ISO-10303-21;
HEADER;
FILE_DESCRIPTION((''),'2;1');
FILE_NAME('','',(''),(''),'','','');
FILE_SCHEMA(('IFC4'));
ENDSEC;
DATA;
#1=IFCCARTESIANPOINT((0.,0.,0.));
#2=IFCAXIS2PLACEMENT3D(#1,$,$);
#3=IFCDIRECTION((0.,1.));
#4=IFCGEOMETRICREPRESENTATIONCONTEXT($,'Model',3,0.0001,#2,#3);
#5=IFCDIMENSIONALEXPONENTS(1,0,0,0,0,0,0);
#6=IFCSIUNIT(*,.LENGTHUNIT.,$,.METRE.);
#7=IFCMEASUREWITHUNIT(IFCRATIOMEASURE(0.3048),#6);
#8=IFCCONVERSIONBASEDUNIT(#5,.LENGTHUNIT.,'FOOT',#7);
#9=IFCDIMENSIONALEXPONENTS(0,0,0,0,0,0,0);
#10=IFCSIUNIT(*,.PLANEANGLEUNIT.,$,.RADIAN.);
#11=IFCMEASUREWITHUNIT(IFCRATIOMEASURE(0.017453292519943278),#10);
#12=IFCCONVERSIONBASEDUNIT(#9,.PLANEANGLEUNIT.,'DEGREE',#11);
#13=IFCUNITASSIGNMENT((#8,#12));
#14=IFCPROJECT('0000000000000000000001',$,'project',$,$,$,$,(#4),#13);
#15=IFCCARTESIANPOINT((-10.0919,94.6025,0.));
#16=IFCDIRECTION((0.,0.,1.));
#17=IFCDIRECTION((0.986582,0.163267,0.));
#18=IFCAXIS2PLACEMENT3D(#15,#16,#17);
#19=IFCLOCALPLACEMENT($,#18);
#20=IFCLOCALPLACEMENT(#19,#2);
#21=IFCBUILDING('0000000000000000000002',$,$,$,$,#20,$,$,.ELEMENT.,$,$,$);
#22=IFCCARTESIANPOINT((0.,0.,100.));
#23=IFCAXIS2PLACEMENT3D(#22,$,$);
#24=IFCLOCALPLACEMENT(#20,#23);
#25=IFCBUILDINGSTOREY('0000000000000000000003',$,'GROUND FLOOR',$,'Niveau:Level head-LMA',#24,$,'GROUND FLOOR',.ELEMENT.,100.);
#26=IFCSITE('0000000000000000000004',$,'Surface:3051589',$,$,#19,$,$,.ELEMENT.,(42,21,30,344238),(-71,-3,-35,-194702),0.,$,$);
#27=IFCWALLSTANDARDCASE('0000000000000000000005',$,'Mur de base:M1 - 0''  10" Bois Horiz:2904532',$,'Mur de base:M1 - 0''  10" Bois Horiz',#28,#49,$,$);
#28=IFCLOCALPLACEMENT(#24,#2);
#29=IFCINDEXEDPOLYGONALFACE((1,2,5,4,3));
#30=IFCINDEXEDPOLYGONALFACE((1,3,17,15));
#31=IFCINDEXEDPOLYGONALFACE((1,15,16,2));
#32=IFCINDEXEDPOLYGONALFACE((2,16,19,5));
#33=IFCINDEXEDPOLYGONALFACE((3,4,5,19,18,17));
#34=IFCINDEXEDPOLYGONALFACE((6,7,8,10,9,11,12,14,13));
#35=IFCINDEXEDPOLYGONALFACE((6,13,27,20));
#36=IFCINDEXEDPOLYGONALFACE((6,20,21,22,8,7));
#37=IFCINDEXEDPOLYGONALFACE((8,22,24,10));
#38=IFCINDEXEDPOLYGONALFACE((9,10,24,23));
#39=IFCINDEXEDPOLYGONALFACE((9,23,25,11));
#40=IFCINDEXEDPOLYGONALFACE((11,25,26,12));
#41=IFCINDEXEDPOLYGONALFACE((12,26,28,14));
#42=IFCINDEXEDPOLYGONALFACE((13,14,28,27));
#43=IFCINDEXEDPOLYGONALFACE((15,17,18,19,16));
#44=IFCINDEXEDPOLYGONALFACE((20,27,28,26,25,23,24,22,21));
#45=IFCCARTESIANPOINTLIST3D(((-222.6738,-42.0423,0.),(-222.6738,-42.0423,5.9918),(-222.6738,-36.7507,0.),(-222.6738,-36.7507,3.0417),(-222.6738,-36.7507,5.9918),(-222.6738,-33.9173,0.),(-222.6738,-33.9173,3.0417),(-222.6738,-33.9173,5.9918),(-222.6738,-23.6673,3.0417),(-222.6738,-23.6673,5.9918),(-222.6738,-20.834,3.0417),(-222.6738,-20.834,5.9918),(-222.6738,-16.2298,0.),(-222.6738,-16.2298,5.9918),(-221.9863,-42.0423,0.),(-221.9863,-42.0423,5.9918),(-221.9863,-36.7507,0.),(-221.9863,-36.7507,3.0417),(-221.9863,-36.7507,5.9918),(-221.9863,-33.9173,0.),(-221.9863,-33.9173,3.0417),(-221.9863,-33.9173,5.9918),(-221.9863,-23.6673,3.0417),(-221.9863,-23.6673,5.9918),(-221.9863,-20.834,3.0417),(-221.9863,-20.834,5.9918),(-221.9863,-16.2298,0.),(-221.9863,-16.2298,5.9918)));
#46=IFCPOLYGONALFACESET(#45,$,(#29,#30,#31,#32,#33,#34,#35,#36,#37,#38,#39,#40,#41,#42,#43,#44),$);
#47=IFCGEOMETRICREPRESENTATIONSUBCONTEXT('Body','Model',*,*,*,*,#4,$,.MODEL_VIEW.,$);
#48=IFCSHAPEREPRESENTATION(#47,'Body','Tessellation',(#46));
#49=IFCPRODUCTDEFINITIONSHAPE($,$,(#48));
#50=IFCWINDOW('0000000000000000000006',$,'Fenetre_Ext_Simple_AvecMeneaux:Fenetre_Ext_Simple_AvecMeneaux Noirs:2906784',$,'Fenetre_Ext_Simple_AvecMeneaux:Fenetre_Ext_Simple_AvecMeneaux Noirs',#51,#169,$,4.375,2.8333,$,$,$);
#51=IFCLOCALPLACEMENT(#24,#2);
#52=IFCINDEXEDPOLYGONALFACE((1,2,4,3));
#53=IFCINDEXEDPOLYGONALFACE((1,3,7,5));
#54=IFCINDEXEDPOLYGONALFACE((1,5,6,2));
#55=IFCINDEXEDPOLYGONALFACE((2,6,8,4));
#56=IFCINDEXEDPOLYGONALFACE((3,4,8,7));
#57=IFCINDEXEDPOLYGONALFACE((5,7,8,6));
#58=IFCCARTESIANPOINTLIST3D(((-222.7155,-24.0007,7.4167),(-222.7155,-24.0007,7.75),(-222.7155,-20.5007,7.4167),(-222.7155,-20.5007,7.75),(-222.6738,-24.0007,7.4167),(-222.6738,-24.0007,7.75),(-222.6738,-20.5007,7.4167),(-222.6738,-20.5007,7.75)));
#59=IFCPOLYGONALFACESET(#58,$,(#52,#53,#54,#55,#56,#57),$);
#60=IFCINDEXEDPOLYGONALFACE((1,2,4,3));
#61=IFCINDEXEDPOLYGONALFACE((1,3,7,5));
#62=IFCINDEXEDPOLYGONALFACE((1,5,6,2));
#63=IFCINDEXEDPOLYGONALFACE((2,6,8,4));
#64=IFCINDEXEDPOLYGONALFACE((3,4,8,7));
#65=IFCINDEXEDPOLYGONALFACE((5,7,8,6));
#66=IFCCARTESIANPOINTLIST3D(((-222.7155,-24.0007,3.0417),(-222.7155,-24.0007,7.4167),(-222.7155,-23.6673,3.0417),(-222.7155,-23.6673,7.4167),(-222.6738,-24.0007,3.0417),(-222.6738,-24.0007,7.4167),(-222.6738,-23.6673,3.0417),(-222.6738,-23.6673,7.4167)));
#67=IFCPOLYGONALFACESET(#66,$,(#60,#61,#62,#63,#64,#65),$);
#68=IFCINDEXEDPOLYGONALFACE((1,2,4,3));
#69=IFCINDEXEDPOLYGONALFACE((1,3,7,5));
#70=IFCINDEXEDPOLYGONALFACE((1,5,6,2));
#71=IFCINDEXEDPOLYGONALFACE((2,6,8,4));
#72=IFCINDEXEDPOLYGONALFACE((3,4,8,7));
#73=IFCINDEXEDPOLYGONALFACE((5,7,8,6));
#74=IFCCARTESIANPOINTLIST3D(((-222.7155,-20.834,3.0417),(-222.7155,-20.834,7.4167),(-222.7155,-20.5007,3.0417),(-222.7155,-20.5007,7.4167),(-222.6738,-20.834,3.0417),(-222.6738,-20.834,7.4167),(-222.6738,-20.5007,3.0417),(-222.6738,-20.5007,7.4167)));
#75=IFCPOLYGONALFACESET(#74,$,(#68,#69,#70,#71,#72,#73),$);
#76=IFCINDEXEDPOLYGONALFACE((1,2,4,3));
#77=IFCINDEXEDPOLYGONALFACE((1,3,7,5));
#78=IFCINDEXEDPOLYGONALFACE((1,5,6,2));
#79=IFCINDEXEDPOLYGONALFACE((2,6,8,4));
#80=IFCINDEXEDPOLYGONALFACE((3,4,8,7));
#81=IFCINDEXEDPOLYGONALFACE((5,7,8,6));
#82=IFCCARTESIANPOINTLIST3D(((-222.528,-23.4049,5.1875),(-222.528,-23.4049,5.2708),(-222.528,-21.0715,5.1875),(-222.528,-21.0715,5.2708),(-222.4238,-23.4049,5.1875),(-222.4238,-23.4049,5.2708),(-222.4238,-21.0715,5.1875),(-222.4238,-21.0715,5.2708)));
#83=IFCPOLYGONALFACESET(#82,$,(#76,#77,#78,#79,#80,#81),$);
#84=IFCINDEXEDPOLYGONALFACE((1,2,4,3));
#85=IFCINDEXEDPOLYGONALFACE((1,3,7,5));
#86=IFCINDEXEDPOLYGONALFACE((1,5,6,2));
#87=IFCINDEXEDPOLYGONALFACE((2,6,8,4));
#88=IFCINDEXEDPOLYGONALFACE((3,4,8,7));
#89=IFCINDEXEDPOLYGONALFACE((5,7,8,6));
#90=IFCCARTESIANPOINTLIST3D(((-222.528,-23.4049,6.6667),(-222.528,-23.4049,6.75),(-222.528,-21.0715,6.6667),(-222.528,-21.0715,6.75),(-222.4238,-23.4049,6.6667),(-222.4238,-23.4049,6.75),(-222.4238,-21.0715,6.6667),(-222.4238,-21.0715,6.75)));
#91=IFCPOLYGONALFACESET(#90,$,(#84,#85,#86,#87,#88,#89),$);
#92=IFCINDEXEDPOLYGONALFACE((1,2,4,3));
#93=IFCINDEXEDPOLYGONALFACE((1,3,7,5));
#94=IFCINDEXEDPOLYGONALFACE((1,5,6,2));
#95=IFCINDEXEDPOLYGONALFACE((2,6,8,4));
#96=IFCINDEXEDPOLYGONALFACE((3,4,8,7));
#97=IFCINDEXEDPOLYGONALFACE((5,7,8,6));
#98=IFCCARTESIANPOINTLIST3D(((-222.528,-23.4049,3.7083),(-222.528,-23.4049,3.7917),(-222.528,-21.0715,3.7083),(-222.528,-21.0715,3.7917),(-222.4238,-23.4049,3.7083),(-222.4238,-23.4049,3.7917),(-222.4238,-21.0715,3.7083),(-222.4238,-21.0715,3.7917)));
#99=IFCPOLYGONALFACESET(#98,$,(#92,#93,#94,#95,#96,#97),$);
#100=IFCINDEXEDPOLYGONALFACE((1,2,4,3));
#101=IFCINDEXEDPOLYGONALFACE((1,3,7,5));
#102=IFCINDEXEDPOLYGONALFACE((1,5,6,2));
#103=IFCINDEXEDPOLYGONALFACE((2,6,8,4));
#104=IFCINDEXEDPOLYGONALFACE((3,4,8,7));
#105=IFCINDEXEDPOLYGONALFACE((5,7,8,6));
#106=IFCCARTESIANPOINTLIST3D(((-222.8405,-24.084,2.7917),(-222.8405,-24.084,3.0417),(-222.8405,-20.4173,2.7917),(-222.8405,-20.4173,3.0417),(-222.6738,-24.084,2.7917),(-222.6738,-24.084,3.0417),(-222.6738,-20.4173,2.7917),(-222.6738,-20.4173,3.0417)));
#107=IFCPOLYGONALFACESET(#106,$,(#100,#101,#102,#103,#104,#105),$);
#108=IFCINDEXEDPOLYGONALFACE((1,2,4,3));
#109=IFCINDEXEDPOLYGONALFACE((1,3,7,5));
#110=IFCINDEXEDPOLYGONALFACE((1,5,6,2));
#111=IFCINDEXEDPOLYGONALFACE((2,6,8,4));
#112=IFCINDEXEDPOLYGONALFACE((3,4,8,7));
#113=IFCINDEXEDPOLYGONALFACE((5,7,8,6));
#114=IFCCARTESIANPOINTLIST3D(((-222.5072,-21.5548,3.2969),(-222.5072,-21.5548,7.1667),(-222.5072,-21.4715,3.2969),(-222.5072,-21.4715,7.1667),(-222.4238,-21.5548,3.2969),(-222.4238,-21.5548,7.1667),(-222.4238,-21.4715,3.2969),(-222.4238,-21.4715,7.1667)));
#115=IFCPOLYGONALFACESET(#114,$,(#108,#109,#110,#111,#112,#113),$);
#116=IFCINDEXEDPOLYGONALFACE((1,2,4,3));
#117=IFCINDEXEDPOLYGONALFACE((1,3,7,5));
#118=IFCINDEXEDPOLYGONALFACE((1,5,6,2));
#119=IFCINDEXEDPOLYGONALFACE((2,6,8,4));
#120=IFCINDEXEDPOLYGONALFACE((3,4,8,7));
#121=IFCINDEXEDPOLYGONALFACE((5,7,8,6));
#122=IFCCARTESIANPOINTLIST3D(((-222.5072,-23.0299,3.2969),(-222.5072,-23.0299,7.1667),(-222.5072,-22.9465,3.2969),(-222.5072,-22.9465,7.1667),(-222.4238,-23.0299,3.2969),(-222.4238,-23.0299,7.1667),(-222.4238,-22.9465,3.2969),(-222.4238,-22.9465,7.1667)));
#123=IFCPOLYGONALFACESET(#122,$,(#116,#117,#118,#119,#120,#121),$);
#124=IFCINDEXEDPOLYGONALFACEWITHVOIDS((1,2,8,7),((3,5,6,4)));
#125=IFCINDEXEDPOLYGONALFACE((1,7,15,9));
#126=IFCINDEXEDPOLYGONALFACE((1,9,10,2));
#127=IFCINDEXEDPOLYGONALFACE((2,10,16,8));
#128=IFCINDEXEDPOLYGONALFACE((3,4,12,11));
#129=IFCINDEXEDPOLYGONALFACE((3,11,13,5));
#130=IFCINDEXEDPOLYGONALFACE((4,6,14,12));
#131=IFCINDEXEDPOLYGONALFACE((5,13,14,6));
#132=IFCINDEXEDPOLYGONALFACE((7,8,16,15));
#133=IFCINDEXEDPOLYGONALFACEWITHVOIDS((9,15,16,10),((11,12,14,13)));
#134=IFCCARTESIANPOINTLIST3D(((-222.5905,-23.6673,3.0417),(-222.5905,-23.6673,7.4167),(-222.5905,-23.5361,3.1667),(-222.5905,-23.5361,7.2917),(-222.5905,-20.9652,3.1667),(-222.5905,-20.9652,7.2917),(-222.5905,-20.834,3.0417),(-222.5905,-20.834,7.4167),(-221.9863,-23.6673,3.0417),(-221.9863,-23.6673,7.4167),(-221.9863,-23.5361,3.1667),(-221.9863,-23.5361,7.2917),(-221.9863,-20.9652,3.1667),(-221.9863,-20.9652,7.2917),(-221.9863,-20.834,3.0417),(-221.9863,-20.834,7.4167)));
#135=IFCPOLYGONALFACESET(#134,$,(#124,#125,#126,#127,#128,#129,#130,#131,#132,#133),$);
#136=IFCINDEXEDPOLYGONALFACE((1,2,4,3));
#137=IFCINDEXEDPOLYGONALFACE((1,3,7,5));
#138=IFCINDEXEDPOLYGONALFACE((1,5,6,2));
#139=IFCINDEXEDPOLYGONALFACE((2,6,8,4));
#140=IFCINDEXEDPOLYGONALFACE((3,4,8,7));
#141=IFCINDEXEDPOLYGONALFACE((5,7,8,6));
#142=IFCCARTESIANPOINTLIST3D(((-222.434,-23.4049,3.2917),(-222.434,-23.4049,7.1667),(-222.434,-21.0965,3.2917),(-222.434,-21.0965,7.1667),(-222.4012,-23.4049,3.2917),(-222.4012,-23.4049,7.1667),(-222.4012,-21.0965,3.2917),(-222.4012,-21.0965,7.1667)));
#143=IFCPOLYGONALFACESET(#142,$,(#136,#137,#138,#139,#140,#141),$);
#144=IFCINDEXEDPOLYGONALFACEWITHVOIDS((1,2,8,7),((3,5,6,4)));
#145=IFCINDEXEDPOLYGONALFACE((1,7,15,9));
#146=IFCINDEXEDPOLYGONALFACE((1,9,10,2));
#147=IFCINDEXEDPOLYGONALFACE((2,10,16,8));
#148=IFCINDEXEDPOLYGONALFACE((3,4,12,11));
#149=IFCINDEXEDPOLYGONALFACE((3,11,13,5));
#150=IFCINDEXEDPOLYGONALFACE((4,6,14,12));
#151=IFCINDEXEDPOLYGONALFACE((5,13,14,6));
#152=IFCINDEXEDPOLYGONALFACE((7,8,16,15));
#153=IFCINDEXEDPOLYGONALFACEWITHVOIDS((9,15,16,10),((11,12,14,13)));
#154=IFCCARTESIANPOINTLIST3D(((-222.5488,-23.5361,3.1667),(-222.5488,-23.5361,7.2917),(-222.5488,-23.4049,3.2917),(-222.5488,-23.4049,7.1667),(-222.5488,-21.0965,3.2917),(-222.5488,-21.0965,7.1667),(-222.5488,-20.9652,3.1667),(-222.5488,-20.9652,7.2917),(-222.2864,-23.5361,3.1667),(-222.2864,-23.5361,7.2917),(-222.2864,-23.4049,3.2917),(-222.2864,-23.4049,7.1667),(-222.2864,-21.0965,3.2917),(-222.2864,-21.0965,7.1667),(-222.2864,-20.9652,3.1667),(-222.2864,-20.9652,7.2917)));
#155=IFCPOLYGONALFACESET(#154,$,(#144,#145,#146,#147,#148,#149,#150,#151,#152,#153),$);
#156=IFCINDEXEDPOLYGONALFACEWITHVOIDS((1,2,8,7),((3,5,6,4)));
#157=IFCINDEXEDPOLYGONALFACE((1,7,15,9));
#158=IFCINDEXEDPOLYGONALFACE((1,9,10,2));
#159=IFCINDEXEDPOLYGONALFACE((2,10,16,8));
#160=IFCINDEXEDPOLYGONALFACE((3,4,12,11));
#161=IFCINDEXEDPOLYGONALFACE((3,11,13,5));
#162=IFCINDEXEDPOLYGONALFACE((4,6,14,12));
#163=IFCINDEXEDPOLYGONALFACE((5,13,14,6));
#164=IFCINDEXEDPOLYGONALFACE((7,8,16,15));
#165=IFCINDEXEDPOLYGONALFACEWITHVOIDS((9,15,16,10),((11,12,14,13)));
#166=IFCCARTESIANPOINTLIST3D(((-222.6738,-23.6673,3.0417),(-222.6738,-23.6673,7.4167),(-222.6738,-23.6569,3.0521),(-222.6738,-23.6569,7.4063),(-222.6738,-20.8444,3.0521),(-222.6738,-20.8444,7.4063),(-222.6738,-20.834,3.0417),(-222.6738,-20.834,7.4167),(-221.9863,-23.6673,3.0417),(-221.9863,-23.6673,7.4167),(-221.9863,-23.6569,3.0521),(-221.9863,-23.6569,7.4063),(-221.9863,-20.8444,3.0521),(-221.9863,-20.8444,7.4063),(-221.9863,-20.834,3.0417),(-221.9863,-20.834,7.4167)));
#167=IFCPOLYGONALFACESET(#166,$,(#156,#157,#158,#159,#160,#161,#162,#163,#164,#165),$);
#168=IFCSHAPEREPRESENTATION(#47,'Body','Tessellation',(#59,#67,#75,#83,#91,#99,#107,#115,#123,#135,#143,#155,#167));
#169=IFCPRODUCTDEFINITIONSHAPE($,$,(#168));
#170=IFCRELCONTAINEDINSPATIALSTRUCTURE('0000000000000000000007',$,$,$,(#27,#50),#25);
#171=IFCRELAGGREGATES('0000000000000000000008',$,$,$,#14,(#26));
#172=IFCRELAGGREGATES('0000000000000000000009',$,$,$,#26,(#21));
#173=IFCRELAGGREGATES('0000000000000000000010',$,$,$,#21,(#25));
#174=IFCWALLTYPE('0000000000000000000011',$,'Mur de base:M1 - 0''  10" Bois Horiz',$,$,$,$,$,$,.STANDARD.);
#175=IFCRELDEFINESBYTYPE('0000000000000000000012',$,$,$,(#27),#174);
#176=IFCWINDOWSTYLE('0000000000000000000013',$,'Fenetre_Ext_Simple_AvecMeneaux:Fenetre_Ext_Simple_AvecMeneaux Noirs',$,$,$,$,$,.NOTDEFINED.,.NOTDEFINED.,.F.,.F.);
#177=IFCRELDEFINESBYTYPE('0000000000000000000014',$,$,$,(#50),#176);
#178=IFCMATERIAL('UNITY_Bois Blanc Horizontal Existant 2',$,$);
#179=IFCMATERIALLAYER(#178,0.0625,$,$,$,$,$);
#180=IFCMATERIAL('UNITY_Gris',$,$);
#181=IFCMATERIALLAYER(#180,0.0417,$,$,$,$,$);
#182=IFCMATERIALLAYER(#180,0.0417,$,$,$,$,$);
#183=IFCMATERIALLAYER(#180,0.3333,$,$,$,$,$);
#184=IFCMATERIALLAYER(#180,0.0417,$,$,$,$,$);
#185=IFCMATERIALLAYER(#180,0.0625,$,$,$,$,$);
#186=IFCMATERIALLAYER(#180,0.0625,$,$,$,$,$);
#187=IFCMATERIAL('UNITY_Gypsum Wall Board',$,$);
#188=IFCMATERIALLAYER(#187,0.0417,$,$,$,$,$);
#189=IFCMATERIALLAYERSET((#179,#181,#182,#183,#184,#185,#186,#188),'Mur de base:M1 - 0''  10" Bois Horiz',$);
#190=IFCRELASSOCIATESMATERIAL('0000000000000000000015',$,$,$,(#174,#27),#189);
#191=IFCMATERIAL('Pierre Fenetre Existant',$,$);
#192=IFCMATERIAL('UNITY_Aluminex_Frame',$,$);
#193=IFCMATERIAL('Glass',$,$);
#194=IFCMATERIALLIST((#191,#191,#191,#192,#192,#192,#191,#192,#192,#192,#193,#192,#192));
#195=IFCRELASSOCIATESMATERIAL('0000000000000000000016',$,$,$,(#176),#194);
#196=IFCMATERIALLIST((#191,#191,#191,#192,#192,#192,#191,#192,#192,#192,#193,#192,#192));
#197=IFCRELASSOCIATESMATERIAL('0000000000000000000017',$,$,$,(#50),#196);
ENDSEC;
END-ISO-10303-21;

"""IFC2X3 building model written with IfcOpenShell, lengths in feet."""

from ifc_helpers import new_model, entity, si_unit, converted_unit, direction, frame, frame_2d, origin, origin_2d_with_axis, place, context, subcontext, project, spatial, polyline, rectangle, outline, extrude, clip, bounded_halfspace, source, transform, mapped, material, material_list, layer, layer_set, layer_usage, type_object, type_shapes, element, fill, save


model = new_model("IFC2X3")

# Units and contexts
model_context = context("Model", 3, precision=0.0001, world=origin(), true_north=direction((0.0, 1.0)))
body_context = subcontext(model_context, "Body", "Model", "MODEL_VIEW")
ifc_project = project(units=[converted_unit("LENGTHUNIT", "FOOT", entity("IfcRatioMeasure", 0.3048), si_unit("LENGTHUNIT", "METRE"), dimensions=[1, 0, 0, 0, 0, 0, 0]), converted_unit("PLANEANGLEUNIT", "DEGREE", entity("IfcRatioMeasure", 0.017453292519943278), si_unit("PLANEANGLEUNIT", "RADIAN"), dimensions=[0, 0, 0, 0, 0, 0, 0])], contexts=[model_context])

# Site, building, storey
site_placement = place(None, frame((-10.0919, 94.6025, 0.0), z_axis=(0.0, 0.0, 1.0), x_axis=(0.986582, 0.163267, 0.0)))
site = spatial("IfcSite", under=ifc_project, at=site_placement, Name="Surface:3051589", CompositionType="ELEMENT", RefLatitude=(42, 21, 30, 344238), RefLongitude=(-71, -3, -35, -194702), RefElevation=0.0)
building_placement = place(site_placement, origin())
building = spatial("IfcBuilding", under=site, at=building_placement, CompositionType="ELEMENT")
storey_placement = place(building_placement, frame((0.0, 0.0, 100.0)))
storey = spatial("IfcBuildingStorey", under=building, at=storey_placement, Name="GROUND FLOOR", ObjectType="Niveau:Level head-LMA", LongName="GROUND FLOOR", CompositionType="ELEMENT", Elevation=100.0)

# Shared definitions
ifc_material_1 = material(Name="UNITY_Bois Blanc Horizontal Existant 2")
ifc_layer_1 = layer(ifc_material_1, 0.0625)
ifc_material_2 = material(Name="UNITY_Gris")
ifc_layer_2 = layer(ifc_material_2, 0.0417)
ifc_layer_3 = layer(ifc_material_2, 0.0417)
ifc_layer_4 = layer(ifc_material_2, 0.3333)
ifc_layer_5 = layer(ifc_material_2, 0.0417)
ifc_layer_6 = layer(ifc_material_2, 0.0625)
ifc_layer_7 = layer(ifc_material_2, 0.0625)
ifc_material_3 = material(Name="UNITY_Gypsum Wall Board")
ifc_layer_8 = layer(ifc_material_3, 0.0417)
ifc_layer_set_1 = layer_set([ifc_layer_1, ifc_layer_2, ifc_layer_3, ifc_layer_4, ifc_layer_5, ifc_layer_6, ifc_layer_7, ifc_layer_8], Name="Mur de base:M1 - 0'  10\" Bois Horiz")
wall_type_1 = type_object("IfcWallType", Name="Mur de base:M1 - 0'  10\" Bois Horiz", PredefinedType="STANDARD", material=ifc_layer_set_1)
ifc_material_4 = material(Name="UNITY_Aluminex_Frame")
ifc_material_5 = material(Name="Glass")

# Wall, openings, window
ifc_layer_usage_1 = layer_usage(ifc_layer_set_1, "AXIS2", "NEGATIVE", 0.3438)
wall_1_placement = place(storey_placement, frame((-222.3301, -42.0423, 0.0), z_axis=(0.0, 0.0, 1.0), x_axis=(0.0, 1.0, 0.0)))
wall_1 = element("IfcWallStandardCase", 1, at=wall_1_placement, inside=storey, type_object=wall_type_1, material=ifc_layer_usage_1, Name="Mur de base:M1 - 0'  10\" Bois Horiz:2904532", ObjectType="Mur de base:M1 - 0'  10\" Bois Horiz", context=body_context, shape_type="Clipping", body=[
    clip(extrude(rectangle(XDim=25.8125, YDim=0.6875, at=frame_2d((12.9062, 0.0), x_axis=(-1.0, 0.0))), origin(), (0.0, 0.0, 1.0), 5.9918), bounded_halfspace(frame((0.0, -0.3438, 10.6784), z_axis=(0.0, 0.721387, 0.692532), x_axis=(-1.0, 0.0, 0.0)), False, frame((0.0, -0.3438, 10.6784)), polyline([(0.0, 0.0), (0.6875, 0.0), (8.75, 0.0), (8.75, 0.6875), (0.0, 0.6875), (0.0, 0.0)]))),
])
opening_1_placement = place(wall_1_placement, origin())
element("IfcOpeningElement", 2, at=opening_1_placement, cuts=wall_1, ObjectType="Opening", context=body_context, shape_type="SweptSolid", body=[
    extrude(rectangle(XDim=6.2917, YDim=0.9583, at=frame_2d((0.0, 0.0), x_axis=(0.0, 1.0))), frame((25.8333, 0.1146, 15.1875), z_axis=(0.0, 1.0, 0.0), x_axis=(1.0, 0.0, 0.0)), (0.0, 0.0, 1.0), 7.3958),
])
opening_2_placement = place(wall_1_placement, origin())
element("IfcOpeningElement", 3, at=opening_2_placement, cuts=wall_1, ObjectType="Opening", context=body_context, shape_type="SweptSolid", body=[
    extrude(rectangle(XDim=6.2917, YDim=3.0, at=frame_2d((0.0, 0.0), x_axis=(0.0, 1.0))), frame((24.0833, -5.3438, 15.1875), z_axis=(0.0, 1.0, 0.0), x_axis=(-1.0, 0.0, 0.0)), (0.0, 0.0, 1.0), 10.0),
])
opening_3_placement = place(wall_1_placement, frame((42.0423, -222.3301, 0.0), z_axis=(0.0, 0.0, 1.0), x_axis=(0.0, -1.0, 0.0)))
element("IfcOpeningElement", 4, at=opening_3_placement, cuts=wall_1, ObjectType="Opening", context=body_context, shape_type="SweptSolid", body=[
    extrude(rectangle(XDim=8.0, YDim=2.8333, at=frame_2d((0.0, 0.0), x_axis=(1.0, 0.0))), frame((-217.6738, -35.334, 4.0), z_axis=(-1.0, 0.0, 0.0), x_axis=(0.0, 0.0, 1.0)), (0.0, 0.0, 1.0), 10.0),
])
opening_4_placement = place(wall_1_placement, frame((42.0423, -222.3301, 0.0), z_axis=(0.0, 0.0, 1.0), x_axis=(0.0, -1.0, 0.0)))
element("IfcOpeningElement", 5, at=opening_4_placement, cuts=wall_1, ObjectType="Opening", context=body_context, shape_type="SweptSolid", body=[
    extrude(rectangle(XDim=4.375, YDim=2.8333, at=frame_2d((0.0, 0.0), x_axis=(0.0, 1.0))), frame((-216.9863, -35.334, 5.2292), z_axis=(-1.0, 0.0, 0.0), x_axis=(0.0, -1.0, 0.0)), (0.0, 0.0, 1.0), 10.0),
])
opening_5_placement = place(wall_1_placement, frame((18.375, -0.3438, 3.0417)))
opening_5 = element("IfcOpeningElement", 6, at=opening_5_placement, cuts=wall_1, ObjectType="Opening", context=body_context, shape_type="SweptSolid", body=[
    extrude(rectangle(XDim=4.375, YDim=2.8333, at=frame_2d((2.1875, 1.4167), x_axis=(1.0, 0.0))), frame((0.0, 0.0, 0.0), z_axis=(0.0, 1.0, 0.0), x_axis=(0.0, 0.0, 1.0)), (0.0, 0.0, 1.0), 0.6875),
])
ifc_material_6 = material(Name="Pierre Fenetre Existant")
ifc_material_list_1 = material_list([ifc_material_6, ifc_material_6, ifc_material_6, ifc_material_4, ifc_material_4, ifc_material_4, ifc_material_6, ifc_material_4, ifc_material_4, ifc_material_4, ifc_material_5, ifc_material_4, ifc_material_4])
ifc_material_list_2 = material_list([ifc_material_6, ifc_material_6, ifc_material_6, ifc_material_4, ifc_material_4, ifc_material_4, ifc_material_6, ifc_material_4, ifc_material_4, ifc_material_4, ifc_material_5, ifc_material_4, ifc_material_4])
window_style_1 = type_object("IfcWindowStyle", Name="Fenetre_Ext_Simple_AvecMeneaux:Fenetre_Ext_Simple_AvecMeneaux Noirs", ConstructionType="NOTDEFINED", OperationType="NOTDEFINED", ParameterTakesPrecedence=False, Sizeable=False, material=ifc_material_list_2)
shared_shape_1 = source(origin(), body_context, "Body", "SweptSolid", [
    extrude(rectangle(XDim=3.5, YDim=0.0417, at=frame_2d((0.0, 0.0), x_axis=(1.0, 0.0))), frame((1.4167, 0.7083, 4.375)), (0.0, 0.0, 1.0), 0.3333),
    extrude(rectangle(XDim=0.3333, YDim=0.0417, at=frame_2d((0.0, 0.0), x_axis=(1.0, 0.0))), frame((-0.1667, 0.7083, 0.0)), (0.0, 0.0, 1.0), 4.375),
    extrude(rectangle(XDim=0.3333, YDim=0.0417, at=frame_2d((0.0, 0.0), x_axis=(1.0, 0.0))), frame((3.0, 0.7083, 0.0)), (0.0, 0.0, 1.0), 4.375),
    extrude(rectangle(XDim=2.3333, YDim=0.1042, at=frame_2d((0.0, 0.0), x_axis=(1.0, 0.0))), frame((1.4291, 0.4896, 2.1458), z_axis=(0.0, 0.0, 1.0), x_axis=(-1.0, 0.0, 0.0)), (0.0, 0.0, 1.0), 0.0833),
    extrude(rectangle(XDim=2.3333, YDim=0.1042, at=frame_2d((0.0, 0.0), x_axis=(1.0, 0.0))), frame((1.4291, 0.4896, 3.625), z_axis=(0.0, 0.0, 1.0), x_axis=(-1.0, 0.0, 0.0)), (0.0, 0.0, 1.0), 0.0833),
    extrude(rectangle(XDim=2.3333, YDim=0.1042, at=frame_2d((0.0, 0.0), x_axis=(1.0, 0.0))), frame((1.4291, 0.4896, 0.6667), z_axis=(0.0, 0.0, 1.0), x_axis=(-1.0, 0.0, 0.0)), (0.0, 0.0, 1.0), 0.0833),
    extrude(rectangle(XDim=3.6667, YDim=0.1667, at=frame_2d((0.0, 0.0), x_axis=(1.0, 0.0))), frame((1.4167, 0.7708, -0.25)), (0.0, 0.0, 1.0), 0.25),
    extrude(rectangle(XDim=0.0833, YDim=0.0833, at=frame_2d((0.0, 0.0), x_axis=(1.0, 0.0))), frame((2.1542, 0.4792, 0.2552), z_axis=(0.0, 0.0, 1.0), x_axis=(-1.0, 0.0, 0.0)), (0.0, 0.0, 1.0), 3.8698),
    extrude(rectangle(XDim=0.0833, YDim=0.0833, at=frame_2d((0.0, 0.0), x_axis=(1.0, 0.0))), frame((0.6791, 0.4792, 0.2552), z_axis=(0.0, 0.0, 1.0), x_axis=(-1.0, 0.0, 0.0)), (0.0, 0.0, 1.0), 3.8698),
    extrude(outline(polyline([(-2.1875, -1.4167), (2.1875, -1.4167), (2.1875, 1.4167), (-2.1875, 1.4167), (-2.1875, -1.4167)]), holes=[polyline([(-2.0625, 1.2854), (2.0625, 1.2854), (2.0625, -1.2854), (-2.0625, -1.2854), (-2.0625, 1.2854)])]), frame((1.4167, 0.6042, 2.1875), z_axis=(0.0, -1.0, 0.0), x_axis=(0.0, 0.0, -1.0)), (0.0, 0.0, 1.0), 0.6042),
    extrude(rectangle(XDim=2.3084, YDim=0.0328, at=origin_2d_with_axis()), frame((1.4167, 0.4313, 0.25)), (0.0, 0.0, 1.0), 3.875),
    extrude(outline(polyline([(-1.2854, -2.0625), (1.2854, -2.0625), (1.2854, 2.0625), (-1.2854, 2.0625), (-1.2854, -2.0625)]), holes=[polyline([(-1.1542, -1.9375), (-1.1542, 1.9375), (1.1542, 1.9375), (1.1542, -1.9375), (-1.1542, -1.9375)])]), frame((1.4167, 0.5625, 2.1875), z_axis=(0.0, -1.0, 0.0), x_axis=(-1.0, 0.0, 0.0)), (0.0, 0.0, 1.0), 0.2625),
    extrude(outline(polyline([(-2.1875, -1.4167), (2.1875, -1.4167), (2.1875, 1.4167), (-2.1875, 1.4167), (-2.1875, -1.4167)]), holes=[polyline([(-2.1771, 1.4063), (2.1771, 1.4063), (2.1771, -1.4063), (-2.1771, -1.4063), (-2.1771, 1.4063)])]), frame((1.4167, 0.6875, 2.1875), z_axis=(0.0, -1.0, 0.0), x_axis=(0.0, 0.0, -1.0)), (0.0, 0.0, 1.0), 0.6875),
])
type_shapes(window_style_1, [shared_shape_1])
window_1_placement = place(opening_5_placement, origin())
window_1 = element("IfcWindow", 7, at=window_1_placement, inside=storey, type_object=window_style_1, material=ifc_material_list_1, Name="Fenetre_Ext_Simple_AvecMeneaux:Fenetre_Ext_Simple_AvecMeneaux Noirs:2906784", ObjectType="Fenetre_Ext_Simple_AvecMeneaux:Fenetre_Ext_Simple_AvecMeneaux Noirs", OverallHeight=4.375, OverallWidth=2.8333, context=body_context, shape_type="MappedRepresentation", body=[
    mapped(shared_shape_1, transform((0.0, 0.0, 0.0), scale=1.0)),
])
fill(opening_5, window_1)

save(model, "model.ifc")
